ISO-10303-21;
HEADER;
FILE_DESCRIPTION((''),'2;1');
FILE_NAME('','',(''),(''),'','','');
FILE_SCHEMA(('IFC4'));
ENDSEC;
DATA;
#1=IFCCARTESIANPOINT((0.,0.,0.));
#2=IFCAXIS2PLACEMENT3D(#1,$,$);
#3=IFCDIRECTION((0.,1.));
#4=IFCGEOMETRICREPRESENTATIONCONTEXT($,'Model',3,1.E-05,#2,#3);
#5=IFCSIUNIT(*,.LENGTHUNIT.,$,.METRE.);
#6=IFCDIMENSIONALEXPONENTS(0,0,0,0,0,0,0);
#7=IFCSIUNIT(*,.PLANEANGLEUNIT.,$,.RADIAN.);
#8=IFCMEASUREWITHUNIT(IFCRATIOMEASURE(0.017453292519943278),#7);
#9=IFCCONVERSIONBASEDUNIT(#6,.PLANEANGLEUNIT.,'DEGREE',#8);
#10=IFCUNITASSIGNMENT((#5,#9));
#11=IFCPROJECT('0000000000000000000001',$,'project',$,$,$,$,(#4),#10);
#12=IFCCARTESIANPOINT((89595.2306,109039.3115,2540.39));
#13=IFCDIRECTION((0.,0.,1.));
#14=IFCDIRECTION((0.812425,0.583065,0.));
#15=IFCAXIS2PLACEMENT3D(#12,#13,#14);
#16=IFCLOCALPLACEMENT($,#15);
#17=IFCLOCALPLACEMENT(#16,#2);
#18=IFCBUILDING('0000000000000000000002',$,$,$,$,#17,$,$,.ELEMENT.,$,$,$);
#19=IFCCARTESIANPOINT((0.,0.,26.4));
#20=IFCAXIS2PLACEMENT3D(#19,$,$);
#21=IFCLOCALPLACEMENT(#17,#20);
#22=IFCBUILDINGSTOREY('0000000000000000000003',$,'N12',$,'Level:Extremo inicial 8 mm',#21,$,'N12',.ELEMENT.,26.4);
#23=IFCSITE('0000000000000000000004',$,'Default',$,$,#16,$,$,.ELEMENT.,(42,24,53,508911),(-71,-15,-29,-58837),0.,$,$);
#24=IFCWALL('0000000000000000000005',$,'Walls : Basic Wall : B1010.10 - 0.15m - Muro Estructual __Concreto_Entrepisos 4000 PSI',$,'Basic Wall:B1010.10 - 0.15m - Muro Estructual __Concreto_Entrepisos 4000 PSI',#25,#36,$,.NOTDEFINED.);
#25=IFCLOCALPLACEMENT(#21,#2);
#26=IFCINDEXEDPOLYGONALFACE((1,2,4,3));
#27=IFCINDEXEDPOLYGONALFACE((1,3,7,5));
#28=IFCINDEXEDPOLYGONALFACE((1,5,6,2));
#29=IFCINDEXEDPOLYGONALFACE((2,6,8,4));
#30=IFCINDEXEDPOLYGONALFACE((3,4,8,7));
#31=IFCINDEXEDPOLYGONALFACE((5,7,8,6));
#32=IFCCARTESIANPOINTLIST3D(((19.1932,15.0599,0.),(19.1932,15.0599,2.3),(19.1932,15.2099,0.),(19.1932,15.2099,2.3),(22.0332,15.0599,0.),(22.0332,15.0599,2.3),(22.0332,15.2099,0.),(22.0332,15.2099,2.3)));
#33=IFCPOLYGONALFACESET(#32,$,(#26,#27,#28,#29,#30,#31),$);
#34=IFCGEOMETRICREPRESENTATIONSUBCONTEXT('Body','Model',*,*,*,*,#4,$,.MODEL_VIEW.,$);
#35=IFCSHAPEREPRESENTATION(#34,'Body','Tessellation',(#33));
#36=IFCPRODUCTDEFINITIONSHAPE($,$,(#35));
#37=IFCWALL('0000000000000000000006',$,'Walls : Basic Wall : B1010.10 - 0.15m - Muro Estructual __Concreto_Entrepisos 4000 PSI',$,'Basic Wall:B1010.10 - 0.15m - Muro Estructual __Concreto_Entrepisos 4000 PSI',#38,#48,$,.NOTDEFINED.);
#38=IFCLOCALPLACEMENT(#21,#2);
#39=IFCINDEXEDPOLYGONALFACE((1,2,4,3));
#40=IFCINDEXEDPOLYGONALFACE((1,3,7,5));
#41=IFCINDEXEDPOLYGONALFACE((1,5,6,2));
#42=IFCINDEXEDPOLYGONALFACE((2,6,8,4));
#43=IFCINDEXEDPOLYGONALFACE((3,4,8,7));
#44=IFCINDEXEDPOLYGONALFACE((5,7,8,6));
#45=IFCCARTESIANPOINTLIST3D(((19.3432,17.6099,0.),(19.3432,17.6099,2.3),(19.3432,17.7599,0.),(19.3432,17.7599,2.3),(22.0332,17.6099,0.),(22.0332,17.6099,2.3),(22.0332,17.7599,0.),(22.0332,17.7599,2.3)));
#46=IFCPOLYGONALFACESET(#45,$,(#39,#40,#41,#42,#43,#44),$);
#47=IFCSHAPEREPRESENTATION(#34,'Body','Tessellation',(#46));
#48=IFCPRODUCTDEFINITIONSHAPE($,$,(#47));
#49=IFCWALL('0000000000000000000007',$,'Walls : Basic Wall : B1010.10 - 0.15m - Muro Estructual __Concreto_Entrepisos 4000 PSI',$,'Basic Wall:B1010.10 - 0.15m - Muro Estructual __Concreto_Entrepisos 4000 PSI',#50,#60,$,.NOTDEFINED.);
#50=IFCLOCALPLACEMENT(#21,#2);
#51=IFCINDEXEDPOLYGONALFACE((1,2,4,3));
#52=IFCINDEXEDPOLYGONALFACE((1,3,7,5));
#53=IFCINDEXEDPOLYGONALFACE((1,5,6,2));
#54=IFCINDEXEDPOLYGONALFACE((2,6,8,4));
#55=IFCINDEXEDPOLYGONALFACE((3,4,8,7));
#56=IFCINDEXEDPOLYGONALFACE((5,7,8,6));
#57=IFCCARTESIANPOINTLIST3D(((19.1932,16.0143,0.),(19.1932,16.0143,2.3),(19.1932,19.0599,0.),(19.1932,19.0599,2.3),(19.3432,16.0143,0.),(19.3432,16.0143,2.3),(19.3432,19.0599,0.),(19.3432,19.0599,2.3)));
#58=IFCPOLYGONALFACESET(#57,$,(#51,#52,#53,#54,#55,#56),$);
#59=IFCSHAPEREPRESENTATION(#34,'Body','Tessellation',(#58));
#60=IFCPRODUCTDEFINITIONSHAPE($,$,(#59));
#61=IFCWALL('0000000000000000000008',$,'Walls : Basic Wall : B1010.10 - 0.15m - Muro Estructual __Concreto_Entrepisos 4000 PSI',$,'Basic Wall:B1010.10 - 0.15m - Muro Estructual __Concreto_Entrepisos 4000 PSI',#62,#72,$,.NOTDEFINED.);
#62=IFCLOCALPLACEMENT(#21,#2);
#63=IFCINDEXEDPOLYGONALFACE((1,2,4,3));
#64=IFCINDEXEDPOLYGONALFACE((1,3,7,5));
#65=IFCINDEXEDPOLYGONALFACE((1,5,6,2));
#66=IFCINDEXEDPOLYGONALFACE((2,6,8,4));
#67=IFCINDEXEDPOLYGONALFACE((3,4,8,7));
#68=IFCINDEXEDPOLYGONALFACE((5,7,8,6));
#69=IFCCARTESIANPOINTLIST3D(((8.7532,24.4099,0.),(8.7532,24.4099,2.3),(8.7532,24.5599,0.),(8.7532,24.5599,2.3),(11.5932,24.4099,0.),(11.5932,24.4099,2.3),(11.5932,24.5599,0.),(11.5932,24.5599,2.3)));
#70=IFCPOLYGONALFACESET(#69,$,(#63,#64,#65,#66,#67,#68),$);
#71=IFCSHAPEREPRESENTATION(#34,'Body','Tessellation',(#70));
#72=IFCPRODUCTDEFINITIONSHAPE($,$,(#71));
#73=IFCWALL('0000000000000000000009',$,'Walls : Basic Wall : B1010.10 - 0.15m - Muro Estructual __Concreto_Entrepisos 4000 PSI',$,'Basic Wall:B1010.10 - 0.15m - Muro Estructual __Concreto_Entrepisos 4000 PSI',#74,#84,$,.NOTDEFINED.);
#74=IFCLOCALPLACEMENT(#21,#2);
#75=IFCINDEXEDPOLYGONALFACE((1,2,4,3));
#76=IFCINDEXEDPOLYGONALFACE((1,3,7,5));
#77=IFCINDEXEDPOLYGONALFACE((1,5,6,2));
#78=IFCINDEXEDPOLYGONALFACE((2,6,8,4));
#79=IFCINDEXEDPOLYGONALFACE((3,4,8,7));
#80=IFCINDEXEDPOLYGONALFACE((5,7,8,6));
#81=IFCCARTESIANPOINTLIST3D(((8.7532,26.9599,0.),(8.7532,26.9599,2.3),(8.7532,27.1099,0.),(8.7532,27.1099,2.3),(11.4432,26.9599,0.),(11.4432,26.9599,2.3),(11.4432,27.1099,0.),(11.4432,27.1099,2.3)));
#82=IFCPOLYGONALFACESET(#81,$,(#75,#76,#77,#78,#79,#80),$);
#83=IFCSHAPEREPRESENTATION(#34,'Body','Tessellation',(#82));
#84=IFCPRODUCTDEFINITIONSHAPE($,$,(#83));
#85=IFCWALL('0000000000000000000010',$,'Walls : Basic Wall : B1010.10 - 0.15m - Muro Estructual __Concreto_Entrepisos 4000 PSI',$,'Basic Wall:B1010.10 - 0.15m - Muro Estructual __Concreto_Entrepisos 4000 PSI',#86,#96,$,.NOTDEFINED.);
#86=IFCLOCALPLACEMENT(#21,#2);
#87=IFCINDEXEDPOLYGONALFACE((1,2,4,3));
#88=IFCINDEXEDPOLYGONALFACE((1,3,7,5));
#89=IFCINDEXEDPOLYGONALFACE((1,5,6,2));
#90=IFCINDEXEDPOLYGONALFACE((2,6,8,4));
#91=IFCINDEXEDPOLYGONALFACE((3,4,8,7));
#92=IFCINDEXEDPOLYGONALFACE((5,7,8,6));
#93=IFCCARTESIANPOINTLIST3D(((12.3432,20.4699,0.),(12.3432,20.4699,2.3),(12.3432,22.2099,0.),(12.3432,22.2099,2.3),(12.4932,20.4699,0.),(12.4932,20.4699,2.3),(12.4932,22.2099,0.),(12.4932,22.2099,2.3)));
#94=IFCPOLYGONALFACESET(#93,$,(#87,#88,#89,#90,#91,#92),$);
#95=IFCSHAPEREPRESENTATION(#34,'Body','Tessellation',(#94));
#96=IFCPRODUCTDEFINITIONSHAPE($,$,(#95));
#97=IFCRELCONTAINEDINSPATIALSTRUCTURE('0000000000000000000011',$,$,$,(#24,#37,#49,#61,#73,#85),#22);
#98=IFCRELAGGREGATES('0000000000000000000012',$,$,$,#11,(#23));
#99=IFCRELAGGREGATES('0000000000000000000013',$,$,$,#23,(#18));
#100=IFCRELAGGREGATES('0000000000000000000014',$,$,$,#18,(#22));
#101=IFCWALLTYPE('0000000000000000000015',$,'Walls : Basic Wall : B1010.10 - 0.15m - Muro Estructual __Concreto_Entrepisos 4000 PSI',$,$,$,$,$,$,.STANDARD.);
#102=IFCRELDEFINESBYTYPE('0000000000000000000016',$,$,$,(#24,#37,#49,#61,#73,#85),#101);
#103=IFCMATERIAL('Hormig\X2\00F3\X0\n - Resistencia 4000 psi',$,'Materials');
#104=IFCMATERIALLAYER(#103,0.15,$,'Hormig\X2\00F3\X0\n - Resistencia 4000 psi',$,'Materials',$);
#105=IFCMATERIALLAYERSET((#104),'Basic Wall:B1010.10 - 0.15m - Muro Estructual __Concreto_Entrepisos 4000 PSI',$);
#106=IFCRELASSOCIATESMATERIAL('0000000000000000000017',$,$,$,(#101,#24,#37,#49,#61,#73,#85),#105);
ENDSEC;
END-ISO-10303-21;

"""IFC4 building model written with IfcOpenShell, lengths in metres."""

from ifc_helpers import new_model, entity, si_unit, converted_unit, direction, frame, frame_2d, origin, place, context, subcontext, project, spatial, rectangle, extrude, material, layer, layer_set, layer_usage, type_object, element, save


model = new_model("IFC4")

# Units and contexts
model_context = context("Model", 3, precision=1e-05, world=origin(), true_north=direction((0.0, 1.0)))
body_context = subcontext(model_context, "Body", "Model", "MODEL_VIEW")
ifc_project = project(units=[si_unit("LENGTHUNIT", "METRE"), converted_unit("PLANEANGLEUNIT", "DEGREE", entity("IfcRatioMeasure", 0.017453292519943278), si_unit("PLANEANGLEUNIT", "RADIAN"), dimensions=[0, 0, 0, 0, 0, 0, 0])], contexts=[model_context])

# Site, building, storey
site_placement = place(None, frame((89595.2306, 109039.3115, 2540.39), z_axis=(0.0, 0.0, 1.0), x_axis=(0.812425, 0.583065, 0.0)))
site = spatial("IfcSite", under=ifc_project, at=site_placement, Name="Default", CompositionType="ELEMENT", RefLatitude=(42, 24, 53, 508911), RefLongitude=(-71, -15, -29, -58837), RefElevation=0.0)
building_placement = place(site_placement, origin())
building = spatial("IfcBuilding", under=site, at=building_placement, CompositionType="ELEMENT")
storey_placement = place(building_placement, frame((0.0, 0.0, 26.4)))
storey = spatial("IfcBuildingStorey", under=building, at=storey_placement, Name="N12", ObjectType="Level:Extremo inicial 8 mm", LongName="N12", CompositionType="ELEMENT", Elevation=26.4)

# Walls
ifc_material = material(Name="Hormigón - Resistencia 4000 psi", Category="Materials")
ifc_layer_1 = layer(ifc_material, 0.15, Name="Hormigón - Resistencia 4000 psi", Category="Materials")
ifc_layer_set_1 = layer_set([ifc_layer_1], Name="Basic Wall:B1010.10 - 0.15m - Muro Estructual __Concreto_Entrepisos 4000 PSI")
ifc_layer_usage_1 = layer_usage(ifc_layer_set_1, "AXIS2", "NEGATIVE", 0.075)
wall_type_1 = type_object("IfcWallType", Name="Walls : Basic Wall : B1010.10 - 0.15m - Muro Estructual __Concreto_Entrepisos 4000 PSI", PredefinedType="STANDARD", material=ifc_layer_set_1)
wall_1_placement = place(storey_placement, frame((22.0332, 15.1349, 0.0), z_axis=(0.0, 0.0, 1.0), x_axis=(-1.0, 0.0, 0.0)))
element("IfcWall", 1, at=wall_1_placement, inside=storey, type_object=wall_type_1, material=ifc_layer_usage_1, Name="Walls : Basic Wall : B1010.10 - 0.15m - Muro Estructual __Concreto_Entrepisos 4000 PSI", ObjectType="Basic Wall:B1010.10 - 0.15m - Muro Estructual __Concreto_Entrepisos 4000 PSI", PredefinedType="NOTDEFINED", context=body_context, shape_type="SweptSolid", body=[
    extrude(rectangle(XDim=2.84, YDim=0.15, at=frame_2d((1.42, 0.0), x_axis=(-1.0, 0.0))), origin(), (0.0, 0.0, 1.0), 2.3),
])
ifc_layer_usage_2 = layer_usage(ifc_layer_set_1, "AXIS2", "NEGATIVE", 0.075)
wall_2_placement = place(storey_placement, frame((22.0332, 17.6849, 0.0), z_axis=(0.0, 0.0, 1.0), x_axis=(-1.0, 0.0, 0.0)))
element("IfcWall", 2, at=wall_2_placement, inside=storey, type_object=wall_type_1, material=ifc_layer_usage_2, Name="Walls : Basic Wall : B1010.10 - 0.15m - Muro Estructual __Concreto_Entrepisos 4000 PSI", ObjectType="Basic Wall:B1010.10 - 0.15m - Muro Estructual __Concreto_Entrepisos 4000 PSI", PredefinedType="NOTDEFINED", context=body_context, shape_type="SweptSolid", body=[
    extrude(rectangle(XDim=2.69, YDim=0.15, at=frame_2d((1.345, 0.0), x_axis=(-1.0, 0.0))), origin(), (0.0, 0.0, 1.0), 2.3),
])
ifc_layer_usage_3 = layer_usage(ifc_layer_set_1, "AXIS2", "NEGATIVE", 0.075)
wall_3_placement = place(storey_placement, frame((19.2682, 16.0143, 0.0), z_axis=(0.0, 0.0, 1.0), x_axis=(0.0, 1.0, 0.0)))
element("IfcWall", 3, at=wall_3_placement, inside=storey, type_object=wall_type_1, material=ifc_layer_usage_3, Name="Walls : Basic Wall : B1010.10 - 0.15m - Muro Estructual __Concreto_Entrepisos 4000 PSI", ObjectType="Basic Wall:B1010.10 - 0.15m - Muro Estructual __Concreto_Entrepisos 4000 PSI", PredefinedType="NOTDEFINED", context=body_context, shape_type="SweptSolid", body=[
    extrude(rectangle(XDim=3.0455, YDim=0.15, at=frame_2d((1.5228, 0.0), x_axis=(-1.0, 0.0))), origin(), (0.0, 0.0, 1.0), 2.3),
])
ifc_layer_usage_4 = layer_usage(ifc_layer_set_1, "AXIS2", "NEGATIVE", 0.075)
wall_4_placement = place(storey_placement, frame((8.7532, 24.4849, 0.0)))
element("IfcWall", 4, at=wall_4_placement, inside=storey, type_object=wall_type_1, material=ifc_layer_usage_4, Name="Walls : Basic Wall : B1010.10 - 0.15m - Muro Estructual __Concreto_Entrepisos 4000 PSI", ObjectType="Basic Wall:B1010.10 - 0.15m - Muro Estructual __Concreto_Entrepisos 4000 PSI", PredefinedType="NOTDEFINED", context=body_context, shape_type="SweptSolid", body=[
    extrude(rectangle(XDim=2.84, YDim=0.15, at=frame_2d((1.42, 0.0), x_axis=(-1.0, 0.0))), origin(), (0.0, 0.0, 1.0), 2.3),
])
ifc_layer_usage_5 = layer_usage(ifc_layer_set_1, "AXIS2", "NEGATIVE", 0.075)
wall_5_placement = place(storey_placement, frame((8.7532, 27.0349, 0.0)))
element("IfcWall", 5, at=wall_5_placement, inside=storey, type_object=wall_type_1, material=ifc_layer_usage_5, Name="Walls : Basic Wall : B1010.10 - 0.15m - Muro Estructual __Concreto_Entrepisos 4000 PSI", ObjectType="Basic Wall:B1010.10 - 0.15m - Muro Estructual __Concreto_Entrepisos 4000 PSI", PredefinedType="NOTDEFINED", context=body_context, shape_type="SweptSolid", body=[
    extrude(rectangle(XDim=2.69, YDim=0.15, at=frame_2d((1.345, 0.0), x_axis=(-1.0, 0.0))), origin(), (0.0, 0.0, 1.0), 2.3),
])
ifc_layer_usage_6 = layer_usage(ifc_layer_set_1, "AXIS2", "POSITIVE", -0.075)
wall_6_placement = place(storey_placement, frame((12.4182, 20.4699, 0.0), z_axis=(0.0, 0.0, 1.0), x_axis=(0.0, 1.0, 0.0)))
element("IfcWall", 6, at=wall_6_placement, inside=storey, type_object=wall_type_1, material=ifc_layer_usage_6, Name="Walls : Basic Wall : B1010.10 - 0.15m - Muro Estructual __Concreto_Entrepisos 4000 PSI", ObjectType="Basic Wall:B1010.10 - 0.15m - Muro Estructual __Concreto_Entrepisos 4000 PSI", PredefinedType="NOTDEFINED", context=body_context, shape_type="SweptSolid", body=[
    extrude(rectangle(XDim=1.74, YDim=0.15, at=frame_2d((0.87, 0.0), x_axis=(-1.0, 0.0))), origin(), (0.0, 0.0, 1.0), 2.3),
])

save(model, "model.ifc")
